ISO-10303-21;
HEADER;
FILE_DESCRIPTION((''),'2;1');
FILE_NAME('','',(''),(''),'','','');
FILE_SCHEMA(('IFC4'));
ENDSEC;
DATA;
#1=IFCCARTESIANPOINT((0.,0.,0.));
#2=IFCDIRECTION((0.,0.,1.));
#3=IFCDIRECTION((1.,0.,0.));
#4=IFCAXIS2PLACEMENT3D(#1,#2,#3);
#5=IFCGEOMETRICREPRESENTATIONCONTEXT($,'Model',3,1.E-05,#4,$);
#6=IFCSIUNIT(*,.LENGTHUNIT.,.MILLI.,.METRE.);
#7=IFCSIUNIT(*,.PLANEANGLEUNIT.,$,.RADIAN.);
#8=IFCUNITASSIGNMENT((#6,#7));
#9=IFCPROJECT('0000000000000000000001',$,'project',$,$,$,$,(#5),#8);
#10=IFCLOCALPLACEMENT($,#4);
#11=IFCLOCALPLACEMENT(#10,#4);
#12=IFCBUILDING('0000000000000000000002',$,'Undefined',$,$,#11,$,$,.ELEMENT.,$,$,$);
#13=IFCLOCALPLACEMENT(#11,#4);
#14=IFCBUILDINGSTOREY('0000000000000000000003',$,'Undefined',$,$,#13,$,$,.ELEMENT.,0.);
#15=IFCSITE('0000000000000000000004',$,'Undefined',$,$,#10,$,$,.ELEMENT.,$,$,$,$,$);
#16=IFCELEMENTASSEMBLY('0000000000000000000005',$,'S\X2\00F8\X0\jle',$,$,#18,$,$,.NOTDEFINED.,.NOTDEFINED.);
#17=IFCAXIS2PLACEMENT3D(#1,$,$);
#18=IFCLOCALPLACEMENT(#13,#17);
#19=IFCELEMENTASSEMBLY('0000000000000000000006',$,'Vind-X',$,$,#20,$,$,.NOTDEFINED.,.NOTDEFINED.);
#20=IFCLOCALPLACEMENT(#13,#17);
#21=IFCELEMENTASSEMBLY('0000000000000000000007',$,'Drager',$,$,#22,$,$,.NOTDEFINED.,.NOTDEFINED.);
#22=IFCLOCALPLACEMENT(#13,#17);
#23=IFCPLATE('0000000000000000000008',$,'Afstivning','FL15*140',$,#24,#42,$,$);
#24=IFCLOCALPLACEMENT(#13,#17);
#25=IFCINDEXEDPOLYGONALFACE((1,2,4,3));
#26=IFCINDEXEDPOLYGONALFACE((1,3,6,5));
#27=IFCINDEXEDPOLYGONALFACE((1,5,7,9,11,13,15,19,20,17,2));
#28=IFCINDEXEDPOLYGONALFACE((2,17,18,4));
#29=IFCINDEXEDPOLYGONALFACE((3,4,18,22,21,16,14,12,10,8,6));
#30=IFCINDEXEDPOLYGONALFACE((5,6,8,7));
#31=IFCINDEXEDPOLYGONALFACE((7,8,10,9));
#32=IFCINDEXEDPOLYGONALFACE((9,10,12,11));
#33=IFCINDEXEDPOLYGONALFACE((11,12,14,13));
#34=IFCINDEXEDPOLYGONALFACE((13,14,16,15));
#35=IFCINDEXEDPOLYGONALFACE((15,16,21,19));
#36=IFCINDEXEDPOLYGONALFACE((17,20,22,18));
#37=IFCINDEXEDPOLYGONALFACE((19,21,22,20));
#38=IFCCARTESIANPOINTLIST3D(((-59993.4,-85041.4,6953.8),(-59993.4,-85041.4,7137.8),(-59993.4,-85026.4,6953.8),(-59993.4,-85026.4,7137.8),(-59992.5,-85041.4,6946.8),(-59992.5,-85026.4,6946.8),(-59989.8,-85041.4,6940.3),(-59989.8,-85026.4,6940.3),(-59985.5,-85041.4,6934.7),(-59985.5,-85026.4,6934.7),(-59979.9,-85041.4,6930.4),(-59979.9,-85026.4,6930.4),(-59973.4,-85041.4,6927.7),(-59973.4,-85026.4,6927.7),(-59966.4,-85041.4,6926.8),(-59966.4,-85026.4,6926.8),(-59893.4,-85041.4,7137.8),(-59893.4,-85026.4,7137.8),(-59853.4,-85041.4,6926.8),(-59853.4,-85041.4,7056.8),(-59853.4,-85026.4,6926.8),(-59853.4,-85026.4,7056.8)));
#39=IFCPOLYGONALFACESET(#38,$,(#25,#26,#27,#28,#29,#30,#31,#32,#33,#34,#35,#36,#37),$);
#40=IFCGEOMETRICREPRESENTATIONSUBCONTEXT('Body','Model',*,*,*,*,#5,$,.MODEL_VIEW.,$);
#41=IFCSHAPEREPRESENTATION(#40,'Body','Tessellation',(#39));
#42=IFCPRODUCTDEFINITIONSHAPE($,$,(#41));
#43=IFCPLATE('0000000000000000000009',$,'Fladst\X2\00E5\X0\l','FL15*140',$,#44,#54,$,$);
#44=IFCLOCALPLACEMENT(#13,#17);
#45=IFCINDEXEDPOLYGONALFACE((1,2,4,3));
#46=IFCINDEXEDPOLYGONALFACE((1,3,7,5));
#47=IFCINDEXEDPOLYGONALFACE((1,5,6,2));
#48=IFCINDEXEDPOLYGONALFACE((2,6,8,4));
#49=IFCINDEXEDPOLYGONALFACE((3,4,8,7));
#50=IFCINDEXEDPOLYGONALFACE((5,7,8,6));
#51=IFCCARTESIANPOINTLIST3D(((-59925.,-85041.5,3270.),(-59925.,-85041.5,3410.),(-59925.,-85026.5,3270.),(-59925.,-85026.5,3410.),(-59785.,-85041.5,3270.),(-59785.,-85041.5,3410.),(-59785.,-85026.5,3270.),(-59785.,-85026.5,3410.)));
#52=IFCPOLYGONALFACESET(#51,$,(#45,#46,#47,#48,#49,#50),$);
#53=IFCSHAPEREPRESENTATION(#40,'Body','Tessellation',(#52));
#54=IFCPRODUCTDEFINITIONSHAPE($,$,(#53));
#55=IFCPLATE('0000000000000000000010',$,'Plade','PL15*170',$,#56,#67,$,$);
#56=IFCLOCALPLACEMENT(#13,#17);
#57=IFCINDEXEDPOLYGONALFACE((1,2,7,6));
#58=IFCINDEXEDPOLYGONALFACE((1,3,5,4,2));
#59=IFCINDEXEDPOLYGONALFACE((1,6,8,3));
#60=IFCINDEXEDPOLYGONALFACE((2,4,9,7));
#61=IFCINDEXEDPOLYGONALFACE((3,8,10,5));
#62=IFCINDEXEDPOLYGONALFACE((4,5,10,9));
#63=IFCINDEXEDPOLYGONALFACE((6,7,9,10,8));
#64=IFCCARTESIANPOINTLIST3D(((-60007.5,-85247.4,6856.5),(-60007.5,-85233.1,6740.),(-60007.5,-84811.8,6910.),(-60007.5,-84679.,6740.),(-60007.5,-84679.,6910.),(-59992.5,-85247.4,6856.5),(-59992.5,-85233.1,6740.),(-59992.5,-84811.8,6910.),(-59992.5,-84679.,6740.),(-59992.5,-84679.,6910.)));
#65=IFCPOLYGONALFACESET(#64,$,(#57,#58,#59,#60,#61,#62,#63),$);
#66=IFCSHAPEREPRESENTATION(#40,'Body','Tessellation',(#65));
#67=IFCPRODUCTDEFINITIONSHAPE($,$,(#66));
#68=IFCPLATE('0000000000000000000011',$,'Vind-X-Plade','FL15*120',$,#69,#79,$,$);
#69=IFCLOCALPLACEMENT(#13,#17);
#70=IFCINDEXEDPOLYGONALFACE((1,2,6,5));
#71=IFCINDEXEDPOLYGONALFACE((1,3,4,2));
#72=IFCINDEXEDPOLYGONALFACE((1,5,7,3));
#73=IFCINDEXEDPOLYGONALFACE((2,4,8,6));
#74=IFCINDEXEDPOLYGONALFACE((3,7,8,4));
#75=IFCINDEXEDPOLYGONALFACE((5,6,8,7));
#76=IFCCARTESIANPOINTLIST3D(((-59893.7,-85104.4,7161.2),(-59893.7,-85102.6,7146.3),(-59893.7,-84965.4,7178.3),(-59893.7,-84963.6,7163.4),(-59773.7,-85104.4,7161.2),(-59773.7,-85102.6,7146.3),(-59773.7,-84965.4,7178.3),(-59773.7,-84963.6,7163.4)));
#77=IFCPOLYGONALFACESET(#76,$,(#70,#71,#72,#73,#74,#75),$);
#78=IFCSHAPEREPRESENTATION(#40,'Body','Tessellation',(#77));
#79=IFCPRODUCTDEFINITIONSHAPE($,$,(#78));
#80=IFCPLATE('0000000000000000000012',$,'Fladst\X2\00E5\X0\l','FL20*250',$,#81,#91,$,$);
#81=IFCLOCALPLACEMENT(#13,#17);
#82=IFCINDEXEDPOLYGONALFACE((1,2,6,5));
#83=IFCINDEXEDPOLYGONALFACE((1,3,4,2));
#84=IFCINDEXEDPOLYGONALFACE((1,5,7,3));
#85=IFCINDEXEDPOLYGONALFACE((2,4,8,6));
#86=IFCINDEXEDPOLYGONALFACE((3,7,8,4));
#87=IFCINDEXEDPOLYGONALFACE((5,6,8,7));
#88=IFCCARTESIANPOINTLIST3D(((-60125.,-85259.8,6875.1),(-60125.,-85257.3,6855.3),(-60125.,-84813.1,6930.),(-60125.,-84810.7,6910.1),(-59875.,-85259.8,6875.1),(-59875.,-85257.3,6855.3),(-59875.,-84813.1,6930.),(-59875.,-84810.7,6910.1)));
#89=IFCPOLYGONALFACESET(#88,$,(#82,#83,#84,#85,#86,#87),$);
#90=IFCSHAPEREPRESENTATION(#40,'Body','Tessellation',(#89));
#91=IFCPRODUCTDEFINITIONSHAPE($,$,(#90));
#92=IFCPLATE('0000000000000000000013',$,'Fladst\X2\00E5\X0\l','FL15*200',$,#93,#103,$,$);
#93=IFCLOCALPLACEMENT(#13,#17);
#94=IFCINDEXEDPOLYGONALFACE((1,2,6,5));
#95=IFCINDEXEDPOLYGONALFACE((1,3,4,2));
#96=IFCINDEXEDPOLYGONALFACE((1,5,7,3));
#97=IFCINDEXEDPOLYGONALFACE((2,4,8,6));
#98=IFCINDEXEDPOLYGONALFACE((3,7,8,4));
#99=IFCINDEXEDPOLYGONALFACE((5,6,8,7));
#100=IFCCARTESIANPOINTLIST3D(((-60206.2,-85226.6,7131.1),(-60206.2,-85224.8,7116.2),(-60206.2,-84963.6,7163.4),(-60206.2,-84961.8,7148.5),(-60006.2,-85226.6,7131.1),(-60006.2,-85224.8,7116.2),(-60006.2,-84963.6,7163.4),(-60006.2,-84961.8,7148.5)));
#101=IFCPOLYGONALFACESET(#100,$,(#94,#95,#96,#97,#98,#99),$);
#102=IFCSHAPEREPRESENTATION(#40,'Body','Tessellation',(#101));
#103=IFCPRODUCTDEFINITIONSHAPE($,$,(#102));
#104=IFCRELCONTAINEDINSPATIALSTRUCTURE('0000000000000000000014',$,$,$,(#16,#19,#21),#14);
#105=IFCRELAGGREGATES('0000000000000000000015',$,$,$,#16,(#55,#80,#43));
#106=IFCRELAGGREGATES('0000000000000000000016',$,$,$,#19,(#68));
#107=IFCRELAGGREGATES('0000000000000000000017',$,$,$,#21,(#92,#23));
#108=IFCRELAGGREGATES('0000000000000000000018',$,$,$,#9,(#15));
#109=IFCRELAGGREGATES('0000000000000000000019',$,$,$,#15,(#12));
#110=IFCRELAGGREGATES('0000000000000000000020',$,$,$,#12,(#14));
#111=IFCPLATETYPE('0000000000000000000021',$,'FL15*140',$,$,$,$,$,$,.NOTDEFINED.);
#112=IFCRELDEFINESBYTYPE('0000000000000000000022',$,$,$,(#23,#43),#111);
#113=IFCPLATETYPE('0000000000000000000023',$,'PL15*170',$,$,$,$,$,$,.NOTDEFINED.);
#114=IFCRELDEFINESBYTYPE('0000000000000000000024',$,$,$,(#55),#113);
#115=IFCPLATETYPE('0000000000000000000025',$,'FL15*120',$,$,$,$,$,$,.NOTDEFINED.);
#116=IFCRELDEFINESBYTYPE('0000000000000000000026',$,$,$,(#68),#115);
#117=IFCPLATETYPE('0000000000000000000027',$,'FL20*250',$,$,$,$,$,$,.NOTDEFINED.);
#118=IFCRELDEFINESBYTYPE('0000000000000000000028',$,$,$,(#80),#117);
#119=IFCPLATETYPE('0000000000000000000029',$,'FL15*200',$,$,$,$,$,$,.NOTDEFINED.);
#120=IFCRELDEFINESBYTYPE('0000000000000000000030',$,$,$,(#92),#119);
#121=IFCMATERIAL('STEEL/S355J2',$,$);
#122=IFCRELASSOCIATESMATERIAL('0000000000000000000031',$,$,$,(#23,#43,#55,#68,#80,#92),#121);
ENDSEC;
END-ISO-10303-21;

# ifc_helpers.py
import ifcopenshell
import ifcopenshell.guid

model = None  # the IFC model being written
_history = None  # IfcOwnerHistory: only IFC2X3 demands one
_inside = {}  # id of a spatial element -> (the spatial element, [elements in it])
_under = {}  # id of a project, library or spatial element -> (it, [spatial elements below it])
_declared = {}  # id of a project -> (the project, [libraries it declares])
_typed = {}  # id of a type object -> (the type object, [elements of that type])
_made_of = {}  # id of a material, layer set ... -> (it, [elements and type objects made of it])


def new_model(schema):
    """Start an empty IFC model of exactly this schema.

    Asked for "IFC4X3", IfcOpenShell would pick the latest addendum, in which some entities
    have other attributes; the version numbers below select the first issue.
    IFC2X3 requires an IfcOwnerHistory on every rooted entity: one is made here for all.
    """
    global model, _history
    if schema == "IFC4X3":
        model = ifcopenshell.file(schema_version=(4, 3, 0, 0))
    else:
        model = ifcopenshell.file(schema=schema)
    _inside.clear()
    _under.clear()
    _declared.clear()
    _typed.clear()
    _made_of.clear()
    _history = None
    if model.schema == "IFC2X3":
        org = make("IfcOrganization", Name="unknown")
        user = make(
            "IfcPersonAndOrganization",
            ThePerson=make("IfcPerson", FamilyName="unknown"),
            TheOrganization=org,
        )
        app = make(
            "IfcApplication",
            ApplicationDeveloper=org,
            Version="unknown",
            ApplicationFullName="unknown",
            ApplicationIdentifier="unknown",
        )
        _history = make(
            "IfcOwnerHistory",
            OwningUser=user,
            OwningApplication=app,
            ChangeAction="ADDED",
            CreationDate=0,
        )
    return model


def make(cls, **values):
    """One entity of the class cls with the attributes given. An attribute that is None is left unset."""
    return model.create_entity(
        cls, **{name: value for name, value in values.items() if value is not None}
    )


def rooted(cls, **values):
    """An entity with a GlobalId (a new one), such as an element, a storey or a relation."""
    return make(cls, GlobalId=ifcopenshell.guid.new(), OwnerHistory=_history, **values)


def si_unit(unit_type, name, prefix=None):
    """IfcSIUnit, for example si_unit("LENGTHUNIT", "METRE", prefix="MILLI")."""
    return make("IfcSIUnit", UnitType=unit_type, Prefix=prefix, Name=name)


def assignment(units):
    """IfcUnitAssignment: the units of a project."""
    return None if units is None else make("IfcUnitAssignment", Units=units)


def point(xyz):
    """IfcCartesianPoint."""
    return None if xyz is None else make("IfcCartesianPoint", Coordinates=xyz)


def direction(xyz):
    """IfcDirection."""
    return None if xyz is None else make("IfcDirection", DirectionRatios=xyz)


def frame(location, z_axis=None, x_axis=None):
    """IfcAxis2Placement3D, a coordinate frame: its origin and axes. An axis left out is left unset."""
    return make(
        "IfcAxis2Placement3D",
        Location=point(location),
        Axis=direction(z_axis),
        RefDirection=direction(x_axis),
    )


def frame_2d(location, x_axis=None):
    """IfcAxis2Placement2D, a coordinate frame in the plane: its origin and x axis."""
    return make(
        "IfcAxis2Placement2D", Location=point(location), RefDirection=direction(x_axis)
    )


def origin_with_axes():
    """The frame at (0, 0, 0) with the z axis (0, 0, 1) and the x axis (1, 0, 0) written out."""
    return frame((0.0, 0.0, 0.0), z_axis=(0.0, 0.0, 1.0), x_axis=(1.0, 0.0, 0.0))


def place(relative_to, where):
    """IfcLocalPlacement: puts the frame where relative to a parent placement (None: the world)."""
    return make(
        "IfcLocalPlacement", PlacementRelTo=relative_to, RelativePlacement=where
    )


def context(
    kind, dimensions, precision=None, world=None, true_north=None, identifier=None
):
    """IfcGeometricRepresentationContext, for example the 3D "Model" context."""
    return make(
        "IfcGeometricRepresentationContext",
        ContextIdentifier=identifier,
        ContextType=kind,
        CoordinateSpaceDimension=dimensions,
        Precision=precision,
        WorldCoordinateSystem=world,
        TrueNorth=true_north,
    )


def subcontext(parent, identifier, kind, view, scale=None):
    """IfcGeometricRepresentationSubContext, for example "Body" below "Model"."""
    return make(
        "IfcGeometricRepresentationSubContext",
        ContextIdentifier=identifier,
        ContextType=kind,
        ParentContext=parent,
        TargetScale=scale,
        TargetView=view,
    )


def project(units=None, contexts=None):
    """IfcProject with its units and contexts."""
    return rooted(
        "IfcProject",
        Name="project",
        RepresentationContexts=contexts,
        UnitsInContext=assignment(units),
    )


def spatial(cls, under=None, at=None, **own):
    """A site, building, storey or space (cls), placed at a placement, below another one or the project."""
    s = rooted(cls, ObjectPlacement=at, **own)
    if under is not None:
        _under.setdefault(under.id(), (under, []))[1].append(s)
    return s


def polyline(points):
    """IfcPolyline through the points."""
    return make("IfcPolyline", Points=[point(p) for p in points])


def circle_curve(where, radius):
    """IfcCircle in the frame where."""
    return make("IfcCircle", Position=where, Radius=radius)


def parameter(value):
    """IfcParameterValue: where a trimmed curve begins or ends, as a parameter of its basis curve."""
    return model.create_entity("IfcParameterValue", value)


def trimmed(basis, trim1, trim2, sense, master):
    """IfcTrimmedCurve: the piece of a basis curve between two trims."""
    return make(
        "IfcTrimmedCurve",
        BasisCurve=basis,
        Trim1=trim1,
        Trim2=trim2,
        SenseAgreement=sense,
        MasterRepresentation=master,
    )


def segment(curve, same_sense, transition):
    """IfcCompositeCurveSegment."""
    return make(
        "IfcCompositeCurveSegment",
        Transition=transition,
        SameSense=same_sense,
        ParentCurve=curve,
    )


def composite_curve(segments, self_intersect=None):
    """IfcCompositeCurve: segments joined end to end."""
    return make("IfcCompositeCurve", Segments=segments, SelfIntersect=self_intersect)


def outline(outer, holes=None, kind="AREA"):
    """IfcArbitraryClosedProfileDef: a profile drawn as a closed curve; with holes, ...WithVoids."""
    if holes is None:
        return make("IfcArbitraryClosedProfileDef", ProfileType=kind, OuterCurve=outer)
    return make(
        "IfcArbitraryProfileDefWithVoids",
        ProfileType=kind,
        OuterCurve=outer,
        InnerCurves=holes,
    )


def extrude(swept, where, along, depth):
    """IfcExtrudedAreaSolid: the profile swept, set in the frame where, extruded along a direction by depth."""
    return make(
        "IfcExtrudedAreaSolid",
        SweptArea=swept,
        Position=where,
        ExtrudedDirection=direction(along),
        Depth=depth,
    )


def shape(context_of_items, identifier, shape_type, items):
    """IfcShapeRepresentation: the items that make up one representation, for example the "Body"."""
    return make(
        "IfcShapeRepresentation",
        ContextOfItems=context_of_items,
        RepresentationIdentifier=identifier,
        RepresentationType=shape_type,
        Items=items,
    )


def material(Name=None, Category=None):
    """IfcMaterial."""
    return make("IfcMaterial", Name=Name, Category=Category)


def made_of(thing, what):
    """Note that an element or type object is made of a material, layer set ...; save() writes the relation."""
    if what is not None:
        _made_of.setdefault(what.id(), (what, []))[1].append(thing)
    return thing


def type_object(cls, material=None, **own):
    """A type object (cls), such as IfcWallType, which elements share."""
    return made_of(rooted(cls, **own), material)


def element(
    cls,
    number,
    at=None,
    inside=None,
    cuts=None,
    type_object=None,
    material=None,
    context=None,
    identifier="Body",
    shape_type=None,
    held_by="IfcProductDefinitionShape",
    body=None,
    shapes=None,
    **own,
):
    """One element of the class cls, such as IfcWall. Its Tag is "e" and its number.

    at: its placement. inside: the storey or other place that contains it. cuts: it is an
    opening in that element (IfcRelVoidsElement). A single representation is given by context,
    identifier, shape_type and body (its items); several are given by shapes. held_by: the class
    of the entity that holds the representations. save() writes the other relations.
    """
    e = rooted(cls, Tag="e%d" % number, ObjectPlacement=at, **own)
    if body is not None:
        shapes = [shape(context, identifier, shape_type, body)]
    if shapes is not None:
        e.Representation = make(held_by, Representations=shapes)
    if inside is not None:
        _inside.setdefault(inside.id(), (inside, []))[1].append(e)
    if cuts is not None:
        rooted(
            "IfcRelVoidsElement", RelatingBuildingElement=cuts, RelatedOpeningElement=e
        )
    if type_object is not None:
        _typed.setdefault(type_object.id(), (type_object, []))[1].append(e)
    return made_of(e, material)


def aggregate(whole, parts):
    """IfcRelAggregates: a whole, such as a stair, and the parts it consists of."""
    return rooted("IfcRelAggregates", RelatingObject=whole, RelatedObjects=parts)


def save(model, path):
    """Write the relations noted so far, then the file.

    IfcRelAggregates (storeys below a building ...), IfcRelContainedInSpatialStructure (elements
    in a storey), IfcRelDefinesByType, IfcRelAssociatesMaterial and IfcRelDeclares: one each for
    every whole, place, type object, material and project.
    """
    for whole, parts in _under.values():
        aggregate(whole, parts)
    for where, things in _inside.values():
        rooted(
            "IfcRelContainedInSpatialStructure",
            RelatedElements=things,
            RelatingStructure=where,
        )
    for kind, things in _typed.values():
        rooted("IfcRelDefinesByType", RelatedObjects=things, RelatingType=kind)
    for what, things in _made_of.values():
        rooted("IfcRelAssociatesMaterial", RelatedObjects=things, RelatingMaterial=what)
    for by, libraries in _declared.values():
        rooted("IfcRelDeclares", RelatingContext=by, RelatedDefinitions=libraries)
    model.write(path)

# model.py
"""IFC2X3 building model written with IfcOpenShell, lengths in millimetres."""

from ifc_helpers import new_model, si_unit, frame, frame_2d, origin_with_axes, place, context, subcontext, project, spatial, polyline, circle_curve, parameter, trimmed, segment, composite_curve, outline, extrude, material, type_object, element, aggregate, save


model = new_model("IFC2X3")

# Units and contexts
model_context = context("Model", 3, precision=1e-05, world=origin_with_axes())
body_context = subcontext(model_context, "Body", "Model", "MODEL_VIEW")
ifc_project = project(units=[si_unit("LENGTHUNIT", "METRE", prefix="MILLI"), si_unit("PLANEANGLEUNIT", "RADIAN")], contexts=[model_context])

# Site, building, storey
site_placement = place(None, origin_with_axes())
site = spatial("IfcSite", under=ifc_project, at=site_placement, Name="Undefined", CompositionType="ELEMENT")
building_placement = place(site_placement, origin_with_axes())
building = spatial("IfcBuilding", under=site, at=building_placement, Name="Undefined", CompositionType="ELEMENT")
storey_placement = place(building_placement, origin_with_axes())
storey = spatial("IfcBuildingStorey", under=building, at=storey_placement, Name="Undefined", CompositionType="ELEMENT", Elevation=0.0)

# Element assembly
assembly_1_placement = place(storey_placement, origin_with_axes())
assembly_1 = element("IfcElementAssembly", 1, at=assembly_1_placement, inside=storey, Name="Søjle", AssemblyPlace="NOTDEFINED", PredefinedType="NOTDEFINED")

# Element assembly
assembly_2_placement = place(storey_placement, origin_with_axes())
assembly_2 = element("IfcElementAssembly", 2, at=assembly_2_placement, inside=storey, Name="Vind-X", AssemblyPlace="NOTDEFINED", PredefinedType="NOTDEFINED")

# Shared definitions
ifc_material_1 = material(Name="STEEL/S355J2")

# Element assembly, plate
assembly_3_placement = place(storey_placement, origin_with_axes())
assembly_3 = element("IfcElementAssembly", 3, at=assembly_3_placement, inside=storey, Name="Drager", AssemblyPlace="NOTDEFINED", PredefinedType="NOTDEFINED")
plate_type_1 = type_object("IfcPlateType", Name="FL15*140", PredefinedType="NOTDEFINED")
plate_1_placement = place(assembly_3_placement, frame((-59993.4, -85033.9, 6926.8), z_axis=(0.0, -1.0, 0.0), x_axis=(1.0, 0.0, 0.0)))
plate_1 = element("IfcPlate", 4, at=plate_1_placement, type_object=plate_type_1, material=ifc_material_1, Name="Afstivning", Description="FL15*140", context=body_context, shape_type="SweptSolid", body=[
    extrude(outline(composite_curve([segment(trimmed(circle_curve(frame_2d((27.0, 27.0), x_axis=(-1.0, 0.0)), 27.0), [parameter(0.0)], [parameter(1.570796)], True, "PARAMETER"), True, "CONTINUOUS"), segment(polyline([(27.0, 0.0), (140.0, 0.0), (140.0, 130.0), (100.0, 211.0), (0.0, 211.0), (0.0, 27.0)]), True, "CONTINUOUS")], self_intersect=True)), frame((0.0, 0.0, -7.5), z_axis=(0.0, 0.0, 1.0), x_axis=(1.0, 0.0, 0.0)), (0.0, 0.0, 1.0), 15.0),
])

# Plates
plate_2_placement = place(assembly_1_placement, frame((-59925.0, -85034.0, 3270.0), z_axis=(0.0, -1.0, 0.0), x_axis=(1.0, 0.0, 0.0)))
plate_2 = element("IfcPlate", 5, at=plate_2_placement, type_object=plate_type_1, material=ifc_material_1, Name="Fladstål", Description="FL15*140", context=body_context, shape_type="SweptSolid", body=[
    extrude(outline(polyline([(0.0, 0.0), (140.0, 0.0), (140.0, 140.0), (0.0, 140.0), (0.0, 0.0)])), frame((0.0, 0.0, -7.5), z_axis=(0.0, 0.0, 1.0), x_axis=(1.0, 0.0, 0.0)), (0.0, 0.0, 1.0), 15.0),
])
plate_type_2 = type_object("IfcPlateType", Name="PL15*170", PredefinedType="NOTDEFINED")
plate_3_placement = place(assembly_1_placement, frame((-60000.0, -85247.4, 6856.5), z_axis=(1.0, 0.0, 0.0), x_axis=(0.0, 0.121869, -0.992546)))
plate_3 = element("IfcPlate", 6, at=plate_3_placement, type_object=plate_type_2, material=ifc_material_1, Name="Plade", Description="PL15*170", context=body_context, shape_type="SweptSolid", body=[
    extrude(outline(polyline([(0.0, 0.0), (117.4, 0.0), (184.9, 550.0), (16.2, 570.7), (0.0, 438.9), (0.0, 0.0)])), frame((0.0, 0.0, -7.5), z_axis=(0.0, 0.0, 1.0), x_axis=(1.0, 0.0, 0.0)), (0.0, 0.0, 1.0), 15.0),
])
plate_type_3 = type_object("IfcPlateType", Name="FL15*120", PredefinedType="NOTDEFINED")
plate_4_placement = place(assembly_2_placement, frame((-59893.7, -85034.0, 7162.3), z_axis=(0.0, 0.121869, -0.992546), x_axis=(1.0, 0.0, 0.0)))
plate_4 = element("IfcPlate", 7, at=plate_4_placement, type_object=plate_type_3, material=ifc_material_1, Name="Vind-X-Plade", Description="FL15*120", context=body_context, shape_type="SweptSolid", body=[
    extrude(outline(polyline([(0.0, -70.0), (0.0, 70.0), (120.0, 70.0), (120.0, -70.0), (0.0, -70.0)])), frame((0.0, 0.0, -7.5), z_axis=(0.0, 0.0, 1.0), x_axis=(1.0, 0.0, 0.0)), (0.0, 0.0, 1.0), 15.0),
])
plate_type_4 = type_object("IfcPlateType", Name="FL20*250", PredefinedType="NOTDEFINED")
plate_5_placement = place(assembly_1_placement, frame((-60000.0, -85258.5, 6865.2), z_axis=(0.0, 0.121869, -0.992546), x_axis=(0.0, 0.992546, 0.121869)))
plate_5 = element("IfcPlate", 8, at=plate_5_placement, type_object=plate_type_4, material=ifc_material_1, Name="Fladstål", Description="FL20*250", context=body_context, shape_type="SweptSolid", body=[
    extrude(outline(polyline([(0.0, -125.0), (0.0, 125.0), (450.0, 125.0), (450.0, -125.0), (0.0, -125.0)])), frame((0.0, 0.0, -10.0), z_axis=(0.0, 0.0, 1.0), x_axis=(1.0, 0.0, 0.0)), (0.0, 0.0, 1.0), 20.0),
])
aggregate(assembly_1, [plate_3, plate_5, plate_2])
plate_type_5 = type_object("IfcPlateType", Name="FL15*200", PredefinedType="NOTDEFINED")
plate_6_placement = place(assembly_3_placement, frame((-60006.2, -85225.7, 7123.6), z_axis=(0.0, -0.121869, 0.992546), x_axis=(0.0, 0.992546, 0.121869)))
plate_6 = element("IfcPlate", 9, at=plate_6_placement, type_object=plate_type_5, material=ifc_material_1, Name="Fladstål", Description="FL15*200", context=body_context, shape_type="SweptSolid", body=[
    extrude(outline(polyline([(0.0, 0.0), (265.0, 0.0), (265.0, 200.0), (0.0, 200.0), (0.0, 0.0)])), frame((0.0, 0.0, -7.5), z_axis=(0.0, 0.0, 1.0), x_axis=(1.0, 0.0, 0.0)), (0.0, 0.0, 1.0), 15.0),
])

aggregate(assembly_2, [plate_4])
aggregate(assembly_3, [plate_6, plate_1])

save(model, "model.ifc")
